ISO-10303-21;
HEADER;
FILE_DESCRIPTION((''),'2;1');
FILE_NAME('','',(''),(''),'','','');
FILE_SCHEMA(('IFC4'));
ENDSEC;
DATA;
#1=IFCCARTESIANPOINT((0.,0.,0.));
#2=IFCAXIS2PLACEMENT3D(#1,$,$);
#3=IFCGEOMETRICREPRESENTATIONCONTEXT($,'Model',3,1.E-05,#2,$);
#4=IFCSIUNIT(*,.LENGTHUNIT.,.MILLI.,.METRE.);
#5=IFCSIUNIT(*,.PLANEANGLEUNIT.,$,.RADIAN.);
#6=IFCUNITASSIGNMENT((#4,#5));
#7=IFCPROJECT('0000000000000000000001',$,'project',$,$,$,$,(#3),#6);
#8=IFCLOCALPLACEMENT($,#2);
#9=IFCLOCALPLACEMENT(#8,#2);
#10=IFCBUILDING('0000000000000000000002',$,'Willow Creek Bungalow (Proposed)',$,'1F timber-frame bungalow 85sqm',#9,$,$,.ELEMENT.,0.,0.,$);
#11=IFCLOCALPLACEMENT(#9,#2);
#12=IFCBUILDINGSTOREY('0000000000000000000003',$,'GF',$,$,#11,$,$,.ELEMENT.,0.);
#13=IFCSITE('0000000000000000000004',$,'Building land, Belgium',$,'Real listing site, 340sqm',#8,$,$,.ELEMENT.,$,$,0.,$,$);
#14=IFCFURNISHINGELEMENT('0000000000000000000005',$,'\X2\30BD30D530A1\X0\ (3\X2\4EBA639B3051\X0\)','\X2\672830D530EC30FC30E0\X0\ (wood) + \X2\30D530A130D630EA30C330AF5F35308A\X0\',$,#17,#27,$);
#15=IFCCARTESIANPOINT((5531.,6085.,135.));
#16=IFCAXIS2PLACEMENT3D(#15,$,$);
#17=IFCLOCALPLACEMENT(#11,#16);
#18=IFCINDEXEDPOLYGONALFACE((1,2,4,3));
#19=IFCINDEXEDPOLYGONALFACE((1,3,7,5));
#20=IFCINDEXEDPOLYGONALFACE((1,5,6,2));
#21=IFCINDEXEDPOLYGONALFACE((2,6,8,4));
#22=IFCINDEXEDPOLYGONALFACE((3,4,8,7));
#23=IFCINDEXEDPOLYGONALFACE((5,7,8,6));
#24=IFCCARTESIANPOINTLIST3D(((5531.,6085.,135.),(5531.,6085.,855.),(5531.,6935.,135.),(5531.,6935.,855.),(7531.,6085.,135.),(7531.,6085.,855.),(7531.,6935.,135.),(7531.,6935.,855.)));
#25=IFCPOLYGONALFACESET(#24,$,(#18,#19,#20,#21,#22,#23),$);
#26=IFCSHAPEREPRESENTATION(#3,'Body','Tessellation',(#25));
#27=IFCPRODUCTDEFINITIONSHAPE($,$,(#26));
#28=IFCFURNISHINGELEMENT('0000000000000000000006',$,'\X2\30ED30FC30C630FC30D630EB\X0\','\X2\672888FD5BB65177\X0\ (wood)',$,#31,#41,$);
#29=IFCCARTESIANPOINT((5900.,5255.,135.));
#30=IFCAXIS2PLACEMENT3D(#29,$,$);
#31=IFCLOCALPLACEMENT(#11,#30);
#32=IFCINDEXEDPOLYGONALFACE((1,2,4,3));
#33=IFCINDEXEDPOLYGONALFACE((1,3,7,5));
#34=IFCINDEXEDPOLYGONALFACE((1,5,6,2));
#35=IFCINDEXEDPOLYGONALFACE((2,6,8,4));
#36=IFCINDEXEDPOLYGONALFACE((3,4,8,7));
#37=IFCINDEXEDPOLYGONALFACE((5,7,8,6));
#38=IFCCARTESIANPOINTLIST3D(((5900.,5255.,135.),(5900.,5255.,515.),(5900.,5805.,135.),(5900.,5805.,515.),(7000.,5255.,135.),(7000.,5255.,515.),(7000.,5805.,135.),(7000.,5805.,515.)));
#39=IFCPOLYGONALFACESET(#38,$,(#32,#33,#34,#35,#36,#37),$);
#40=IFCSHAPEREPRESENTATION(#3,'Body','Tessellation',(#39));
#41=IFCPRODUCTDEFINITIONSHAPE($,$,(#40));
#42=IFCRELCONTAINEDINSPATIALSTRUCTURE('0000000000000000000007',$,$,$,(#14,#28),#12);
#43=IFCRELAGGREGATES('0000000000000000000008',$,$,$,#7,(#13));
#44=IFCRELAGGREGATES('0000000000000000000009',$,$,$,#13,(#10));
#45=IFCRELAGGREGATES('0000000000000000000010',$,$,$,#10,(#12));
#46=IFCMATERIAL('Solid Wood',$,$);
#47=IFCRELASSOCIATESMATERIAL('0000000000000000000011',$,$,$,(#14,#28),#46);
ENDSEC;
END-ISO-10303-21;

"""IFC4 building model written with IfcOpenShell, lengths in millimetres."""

from ifc_helpers import new_model, si_unit, frame, frame_2d, origin, place, context, project, spatial, rectangle, extrude, material, element, save


model = new_model("IFC4")

# Units and contexts
model_context = context("Model", 3, precision=1e-05, world=origin())
ifc_project = project(units=[si_unit("LENGTHUNIT", "METRE", prefix="MILLI"), si_unit("PLANEANGLEUNIT", "RADIAN")], contexts=[model_context])

# Site, building, storey
site_placement = place(None, origin())
site = spatial("IfcSite", under=ifc_project, at=site_placement, Name="Building land, Belgium", ObjectType="Real listing site, 340sqm", CompositionType="ELEMENT", RefElevation=0.0)
building_placement = place(site_placement, origin())
building = spatial("IfcBuilding", under=site, at=building_placement, Name="Willow Creek Bungalow (Proposed)", ObjectType="1F timber-frame bungalow 85sqm", CompositionType="ELEMENT", ElevationOfRefHeight=0.0, ElevationOfTerrain=0.0)
storey_placement = place(building_placement, origin())
storey = spatial("IfcBuildingStorey", under=building, at=storey_placement, Name="GF", CompositionType="ELEMENT", Elevation=0.0)

# Shared definitions
ifc_material_1 = material(Name="Solid Wood")

# Furnishing elements
furnishing_1_placement = place(storey_placement, frame((5531.0, 6085.0, 135.0)))
element("IfcFurnishingElement", 1, at=furnishing_1_placement, inside=storey, material=ifc_material_1, Name="ソファ (3人掛け)", Description="木フレーム (wood) + ファブリック張り", context=model_context, shape_type="SweptSolid", body=[
    extrude(rectangle(XDim=2000.0, YDim=850.0, at=frame_2d((1000.0, 425.0))), frame((5531.0, 6085.0, 135.0)), (0.0, 0.0, 1.0), 720.0),
])
furnishing_2_placement = place(storey_placement, frame((5900.0, 5255.0, 135.0)))
element("IfcFurnishingElement", 2, at=furnishing_2_placement, inside=storey, material=ifc_material_1, Name="ローテーブル", Description="木製家具 (wood)", context=model_context, shape_type="SweptSolid", body=[
    extrude(rectangle(XDim=1100.0, YDim=550.0, at=frame_2d((550.0, 275.0))), frame((5900.0, 5255.0, 135.0)), (0.0, 0.0, 1.0), 380.0),
])

save(model, "model.ifc")
